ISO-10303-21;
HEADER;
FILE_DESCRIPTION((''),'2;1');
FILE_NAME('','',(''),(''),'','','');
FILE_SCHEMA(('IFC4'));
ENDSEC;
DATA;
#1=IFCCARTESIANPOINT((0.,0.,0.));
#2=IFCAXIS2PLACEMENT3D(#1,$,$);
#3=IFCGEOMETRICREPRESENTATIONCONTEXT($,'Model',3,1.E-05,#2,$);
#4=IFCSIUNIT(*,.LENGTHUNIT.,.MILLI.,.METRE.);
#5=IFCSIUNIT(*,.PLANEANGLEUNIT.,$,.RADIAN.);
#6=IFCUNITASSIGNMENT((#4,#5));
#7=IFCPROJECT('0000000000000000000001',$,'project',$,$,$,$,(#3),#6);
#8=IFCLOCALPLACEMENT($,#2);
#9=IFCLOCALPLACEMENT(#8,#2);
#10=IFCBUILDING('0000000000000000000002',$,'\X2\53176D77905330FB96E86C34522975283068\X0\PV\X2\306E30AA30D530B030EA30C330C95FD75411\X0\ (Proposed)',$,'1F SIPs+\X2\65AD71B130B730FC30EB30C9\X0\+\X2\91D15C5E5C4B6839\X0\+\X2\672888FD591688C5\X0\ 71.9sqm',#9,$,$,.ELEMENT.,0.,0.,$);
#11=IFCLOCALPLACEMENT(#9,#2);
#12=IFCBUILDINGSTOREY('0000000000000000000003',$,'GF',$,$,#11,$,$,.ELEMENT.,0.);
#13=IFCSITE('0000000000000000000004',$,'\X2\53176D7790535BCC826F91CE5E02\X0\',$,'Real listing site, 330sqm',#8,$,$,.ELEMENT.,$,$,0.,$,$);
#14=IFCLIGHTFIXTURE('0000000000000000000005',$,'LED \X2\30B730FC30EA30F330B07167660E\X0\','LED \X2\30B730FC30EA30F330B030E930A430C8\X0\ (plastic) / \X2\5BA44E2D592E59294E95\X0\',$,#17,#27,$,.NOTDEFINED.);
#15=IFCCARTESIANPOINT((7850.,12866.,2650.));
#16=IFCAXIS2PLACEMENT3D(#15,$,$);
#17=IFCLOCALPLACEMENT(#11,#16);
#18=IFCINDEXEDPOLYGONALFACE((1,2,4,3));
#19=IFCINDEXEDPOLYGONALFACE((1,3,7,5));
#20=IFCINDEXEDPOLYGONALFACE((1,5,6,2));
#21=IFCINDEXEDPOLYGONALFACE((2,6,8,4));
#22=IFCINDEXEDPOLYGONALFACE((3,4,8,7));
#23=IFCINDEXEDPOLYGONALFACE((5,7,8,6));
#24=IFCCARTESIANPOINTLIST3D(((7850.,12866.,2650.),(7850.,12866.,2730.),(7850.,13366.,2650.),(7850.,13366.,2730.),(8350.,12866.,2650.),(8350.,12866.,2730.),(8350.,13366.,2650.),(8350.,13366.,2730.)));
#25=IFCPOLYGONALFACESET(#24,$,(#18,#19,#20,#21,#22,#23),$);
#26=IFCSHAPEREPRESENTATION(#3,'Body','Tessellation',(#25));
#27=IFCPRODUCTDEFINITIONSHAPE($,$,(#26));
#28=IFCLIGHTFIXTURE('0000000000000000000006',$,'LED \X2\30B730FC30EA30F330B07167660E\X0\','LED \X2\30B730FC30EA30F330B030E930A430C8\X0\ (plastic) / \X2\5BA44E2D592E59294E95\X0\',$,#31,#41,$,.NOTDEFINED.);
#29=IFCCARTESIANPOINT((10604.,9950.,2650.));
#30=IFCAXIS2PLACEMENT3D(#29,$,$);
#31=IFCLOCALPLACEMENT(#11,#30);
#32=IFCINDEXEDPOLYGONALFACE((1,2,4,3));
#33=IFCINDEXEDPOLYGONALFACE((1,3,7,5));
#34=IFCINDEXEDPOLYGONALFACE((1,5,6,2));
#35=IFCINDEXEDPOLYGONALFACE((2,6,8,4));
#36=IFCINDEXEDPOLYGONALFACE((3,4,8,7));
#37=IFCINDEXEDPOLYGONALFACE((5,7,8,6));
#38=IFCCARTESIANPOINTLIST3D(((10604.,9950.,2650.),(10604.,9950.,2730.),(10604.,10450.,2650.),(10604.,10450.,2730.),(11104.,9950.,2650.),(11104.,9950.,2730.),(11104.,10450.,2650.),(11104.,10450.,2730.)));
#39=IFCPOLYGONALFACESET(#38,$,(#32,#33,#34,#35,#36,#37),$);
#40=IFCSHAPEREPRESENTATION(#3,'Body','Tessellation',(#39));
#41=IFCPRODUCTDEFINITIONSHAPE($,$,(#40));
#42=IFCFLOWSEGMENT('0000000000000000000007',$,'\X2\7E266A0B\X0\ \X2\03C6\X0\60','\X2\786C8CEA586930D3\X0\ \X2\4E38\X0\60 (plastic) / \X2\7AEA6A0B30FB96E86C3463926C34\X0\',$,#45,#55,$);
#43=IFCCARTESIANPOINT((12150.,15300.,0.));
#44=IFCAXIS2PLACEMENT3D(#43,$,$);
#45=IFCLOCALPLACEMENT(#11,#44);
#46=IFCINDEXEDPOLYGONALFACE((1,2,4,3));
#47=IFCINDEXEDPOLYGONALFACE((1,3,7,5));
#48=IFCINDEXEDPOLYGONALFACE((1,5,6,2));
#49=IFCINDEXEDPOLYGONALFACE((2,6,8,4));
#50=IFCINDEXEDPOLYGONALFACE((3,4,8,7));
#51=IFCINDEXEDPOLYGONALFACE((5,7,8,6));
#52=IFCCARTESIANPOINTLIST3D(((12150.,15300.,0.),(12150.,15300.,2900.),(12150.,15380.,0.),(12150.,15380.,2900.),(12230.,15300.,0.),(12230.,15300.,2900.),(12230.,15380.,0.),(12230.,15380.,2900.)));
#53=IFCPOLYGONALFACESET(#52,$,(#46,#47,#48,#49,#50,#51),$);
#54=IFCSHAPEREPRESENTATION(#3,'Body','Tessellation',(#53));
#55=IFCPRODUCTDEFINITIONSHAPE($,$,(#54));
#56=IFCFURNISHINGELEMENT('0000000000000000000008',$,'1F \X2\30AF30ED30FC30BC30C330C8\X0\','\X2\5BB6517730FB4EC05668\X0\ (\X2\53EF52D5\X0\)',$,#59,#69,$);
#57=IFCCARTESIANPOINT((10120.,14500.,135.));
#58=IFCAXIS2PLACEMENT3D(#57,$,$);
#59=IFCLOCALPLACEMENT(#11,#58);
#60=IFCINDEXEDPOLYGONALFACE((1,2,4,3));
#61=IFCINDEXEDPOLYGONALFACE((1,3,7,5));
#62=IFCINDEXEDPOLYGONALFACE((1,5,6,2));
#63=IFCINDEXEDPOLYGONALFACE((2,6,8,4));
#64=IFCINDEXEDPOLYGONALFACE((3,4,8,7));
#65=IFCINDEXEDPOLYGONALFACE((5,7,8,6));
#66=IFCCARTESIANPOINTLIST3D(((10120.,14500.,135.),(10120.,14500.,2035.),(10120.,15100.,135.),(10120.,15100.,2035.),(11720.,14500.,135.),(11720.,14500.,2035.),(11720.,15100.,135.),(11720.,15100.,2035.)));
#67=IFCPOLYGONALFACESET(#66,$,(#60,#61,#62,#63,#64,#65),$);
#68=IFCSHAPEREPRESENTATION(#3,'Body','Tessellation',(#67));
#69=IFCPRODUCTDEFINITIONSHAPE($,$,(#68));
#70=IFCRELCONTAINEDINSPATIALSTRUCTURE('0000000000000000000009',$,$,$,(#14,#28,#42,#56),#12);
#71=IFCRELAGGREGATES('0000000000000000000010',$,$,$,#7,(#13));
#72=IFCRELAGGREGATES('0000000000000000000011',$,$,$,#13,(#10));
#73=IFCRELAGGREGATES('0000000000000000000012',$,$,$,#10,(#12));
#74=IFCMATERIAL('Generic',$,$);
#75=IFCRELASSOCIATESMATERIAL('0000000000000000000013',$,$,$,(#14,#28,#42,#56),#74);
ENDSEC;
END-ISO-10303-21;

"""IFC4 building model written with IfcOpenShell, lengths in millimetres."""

from ifc_helpers import new_model, si_unit, frame, frame_2d, origin, place, context, project, spatial, rectangle, extrude, material, element, save


model = new_model("IFC4")

# Units and contexts
model_context = context("Model", 3, precision=1e-05, world=origin())
ifc_project = project(units=[si_unit("LENGTHUNIT", "METRE", prefix="MILLI"), si_unit("PLANEANGLEUNIT", "RADIAN")], contexts=[model_context])

# Site, building, storey
site_placement = place(None, origin())
site = spatial("IfcSite", under=ifc_project, at=site_placement, Name="北海道富良野市", ObjectType="Real listing site, 330sqm", CompositionType="ELEMENT", RefElevation=0.0)
building_placement = place(site_placement, origin())
building = spatial("IfcBuilding", under=site, at=building_placement, Name="北海道・雨水利用とPVのオフグリッド志向 (Proposed)", ObjectType="1F SIPs+断熱シールド+金属屋根+木製外装 71.9sqm", CompositionType="ELEMENT", ElevationOfRefHeight=0.0, ElevationOfTerrain=0.0)
storey_placement = place(building_placement, origin())
storey = spatial("IfcBuildingStorey", under=building, at=storey_placement, Name="GF", CompositionType="ELEMENT", Elevation=0.0)

# Shared definitions
ifc_material_1 = material(Name="Generic")

# Light fixtures
light_fixture_1_placement = place(storey_placement, frame((7850.0, 12866.0, 2650.0)))
element("IfcLightFixture", 1, at=light_fixture_1_placement, inside=storey, material=ifc_material_1, Name="LED シーリング照明", Description="LED シーリングライト (plastic) / 室中央天井", PredefinedType="NOTDEFINED", context=model_context, shape_type="SweptSolid", body=[
    extrude(rectangle(XDim=500.0, YDim=500.0, at=frame_2d((250.0, 250.0))), frame((7850.0, 12866.0, 2650.0)), (0.0, 0.0, 1.0), 80.0),
])
light_fixture_2_placement = place(storey_placement, frame((10604.0, 9950.0, 2650.0)))
element("IfcLightFixture", 2, at=light_fixture_2_placement, inside=storey, material=ifc_material_1, Name="LED シーリング照明", Description="LED シーリングライト (plastic) / 室中央天井", PredefinedType="NOTDEFINED", context=model_context, shape_type="SweptSolid", body=[
    extrude(rectangle(XDim=500.0, YDim=500.0, at=frame_2d((250.0, 250.0))), frame((10604.0, 9950.0, 2650.0)), (0.0, 0.0, 1.0), 80.0),
])

# Flow segment
flow_segment_placement = place(storey_placement, frame((12150.0, 15300.0, 0.0)))
element("IfcFlowSegment", 3, at=flow_segment_placement, inside=storey, material=ifc_material_1, Name="縦樋 φ60", Description="硬質塩ビ 丸60 (plastic) / 竪樋・雨水排水", context=model_context, shape_type="SweptSolid", body=[
    extrude(rectangle(XDim=80.0, YDim=80.0, at=frame_2d((40.0, 40.0))), frame((12150.0, 15300.0, 0.0)), (0.0, 0.0, 1.0), 2900.0),
])

# Furnishing element
furnishing_placement = place(storey_placement, frame((10120.0, 14500.0, 135.0)))
element("IfcFurnishingElement", 4, at=furnishing_placement, inside=storey, material=ifc_material_1, Name="1F クローゼット", Description="家具・什器 (可動)", context=model_context, shape_type="SweptSolid", body=[
    extrude(rectangle(XDim=1600.0, YDim=600.0, at=frame_2d((800.0, 300.0))), frame((10120.0, 14500.0, 135.0)), (0.0, 0.0, 1.0), 1900.0),
])

save(model, "model.ifc")
